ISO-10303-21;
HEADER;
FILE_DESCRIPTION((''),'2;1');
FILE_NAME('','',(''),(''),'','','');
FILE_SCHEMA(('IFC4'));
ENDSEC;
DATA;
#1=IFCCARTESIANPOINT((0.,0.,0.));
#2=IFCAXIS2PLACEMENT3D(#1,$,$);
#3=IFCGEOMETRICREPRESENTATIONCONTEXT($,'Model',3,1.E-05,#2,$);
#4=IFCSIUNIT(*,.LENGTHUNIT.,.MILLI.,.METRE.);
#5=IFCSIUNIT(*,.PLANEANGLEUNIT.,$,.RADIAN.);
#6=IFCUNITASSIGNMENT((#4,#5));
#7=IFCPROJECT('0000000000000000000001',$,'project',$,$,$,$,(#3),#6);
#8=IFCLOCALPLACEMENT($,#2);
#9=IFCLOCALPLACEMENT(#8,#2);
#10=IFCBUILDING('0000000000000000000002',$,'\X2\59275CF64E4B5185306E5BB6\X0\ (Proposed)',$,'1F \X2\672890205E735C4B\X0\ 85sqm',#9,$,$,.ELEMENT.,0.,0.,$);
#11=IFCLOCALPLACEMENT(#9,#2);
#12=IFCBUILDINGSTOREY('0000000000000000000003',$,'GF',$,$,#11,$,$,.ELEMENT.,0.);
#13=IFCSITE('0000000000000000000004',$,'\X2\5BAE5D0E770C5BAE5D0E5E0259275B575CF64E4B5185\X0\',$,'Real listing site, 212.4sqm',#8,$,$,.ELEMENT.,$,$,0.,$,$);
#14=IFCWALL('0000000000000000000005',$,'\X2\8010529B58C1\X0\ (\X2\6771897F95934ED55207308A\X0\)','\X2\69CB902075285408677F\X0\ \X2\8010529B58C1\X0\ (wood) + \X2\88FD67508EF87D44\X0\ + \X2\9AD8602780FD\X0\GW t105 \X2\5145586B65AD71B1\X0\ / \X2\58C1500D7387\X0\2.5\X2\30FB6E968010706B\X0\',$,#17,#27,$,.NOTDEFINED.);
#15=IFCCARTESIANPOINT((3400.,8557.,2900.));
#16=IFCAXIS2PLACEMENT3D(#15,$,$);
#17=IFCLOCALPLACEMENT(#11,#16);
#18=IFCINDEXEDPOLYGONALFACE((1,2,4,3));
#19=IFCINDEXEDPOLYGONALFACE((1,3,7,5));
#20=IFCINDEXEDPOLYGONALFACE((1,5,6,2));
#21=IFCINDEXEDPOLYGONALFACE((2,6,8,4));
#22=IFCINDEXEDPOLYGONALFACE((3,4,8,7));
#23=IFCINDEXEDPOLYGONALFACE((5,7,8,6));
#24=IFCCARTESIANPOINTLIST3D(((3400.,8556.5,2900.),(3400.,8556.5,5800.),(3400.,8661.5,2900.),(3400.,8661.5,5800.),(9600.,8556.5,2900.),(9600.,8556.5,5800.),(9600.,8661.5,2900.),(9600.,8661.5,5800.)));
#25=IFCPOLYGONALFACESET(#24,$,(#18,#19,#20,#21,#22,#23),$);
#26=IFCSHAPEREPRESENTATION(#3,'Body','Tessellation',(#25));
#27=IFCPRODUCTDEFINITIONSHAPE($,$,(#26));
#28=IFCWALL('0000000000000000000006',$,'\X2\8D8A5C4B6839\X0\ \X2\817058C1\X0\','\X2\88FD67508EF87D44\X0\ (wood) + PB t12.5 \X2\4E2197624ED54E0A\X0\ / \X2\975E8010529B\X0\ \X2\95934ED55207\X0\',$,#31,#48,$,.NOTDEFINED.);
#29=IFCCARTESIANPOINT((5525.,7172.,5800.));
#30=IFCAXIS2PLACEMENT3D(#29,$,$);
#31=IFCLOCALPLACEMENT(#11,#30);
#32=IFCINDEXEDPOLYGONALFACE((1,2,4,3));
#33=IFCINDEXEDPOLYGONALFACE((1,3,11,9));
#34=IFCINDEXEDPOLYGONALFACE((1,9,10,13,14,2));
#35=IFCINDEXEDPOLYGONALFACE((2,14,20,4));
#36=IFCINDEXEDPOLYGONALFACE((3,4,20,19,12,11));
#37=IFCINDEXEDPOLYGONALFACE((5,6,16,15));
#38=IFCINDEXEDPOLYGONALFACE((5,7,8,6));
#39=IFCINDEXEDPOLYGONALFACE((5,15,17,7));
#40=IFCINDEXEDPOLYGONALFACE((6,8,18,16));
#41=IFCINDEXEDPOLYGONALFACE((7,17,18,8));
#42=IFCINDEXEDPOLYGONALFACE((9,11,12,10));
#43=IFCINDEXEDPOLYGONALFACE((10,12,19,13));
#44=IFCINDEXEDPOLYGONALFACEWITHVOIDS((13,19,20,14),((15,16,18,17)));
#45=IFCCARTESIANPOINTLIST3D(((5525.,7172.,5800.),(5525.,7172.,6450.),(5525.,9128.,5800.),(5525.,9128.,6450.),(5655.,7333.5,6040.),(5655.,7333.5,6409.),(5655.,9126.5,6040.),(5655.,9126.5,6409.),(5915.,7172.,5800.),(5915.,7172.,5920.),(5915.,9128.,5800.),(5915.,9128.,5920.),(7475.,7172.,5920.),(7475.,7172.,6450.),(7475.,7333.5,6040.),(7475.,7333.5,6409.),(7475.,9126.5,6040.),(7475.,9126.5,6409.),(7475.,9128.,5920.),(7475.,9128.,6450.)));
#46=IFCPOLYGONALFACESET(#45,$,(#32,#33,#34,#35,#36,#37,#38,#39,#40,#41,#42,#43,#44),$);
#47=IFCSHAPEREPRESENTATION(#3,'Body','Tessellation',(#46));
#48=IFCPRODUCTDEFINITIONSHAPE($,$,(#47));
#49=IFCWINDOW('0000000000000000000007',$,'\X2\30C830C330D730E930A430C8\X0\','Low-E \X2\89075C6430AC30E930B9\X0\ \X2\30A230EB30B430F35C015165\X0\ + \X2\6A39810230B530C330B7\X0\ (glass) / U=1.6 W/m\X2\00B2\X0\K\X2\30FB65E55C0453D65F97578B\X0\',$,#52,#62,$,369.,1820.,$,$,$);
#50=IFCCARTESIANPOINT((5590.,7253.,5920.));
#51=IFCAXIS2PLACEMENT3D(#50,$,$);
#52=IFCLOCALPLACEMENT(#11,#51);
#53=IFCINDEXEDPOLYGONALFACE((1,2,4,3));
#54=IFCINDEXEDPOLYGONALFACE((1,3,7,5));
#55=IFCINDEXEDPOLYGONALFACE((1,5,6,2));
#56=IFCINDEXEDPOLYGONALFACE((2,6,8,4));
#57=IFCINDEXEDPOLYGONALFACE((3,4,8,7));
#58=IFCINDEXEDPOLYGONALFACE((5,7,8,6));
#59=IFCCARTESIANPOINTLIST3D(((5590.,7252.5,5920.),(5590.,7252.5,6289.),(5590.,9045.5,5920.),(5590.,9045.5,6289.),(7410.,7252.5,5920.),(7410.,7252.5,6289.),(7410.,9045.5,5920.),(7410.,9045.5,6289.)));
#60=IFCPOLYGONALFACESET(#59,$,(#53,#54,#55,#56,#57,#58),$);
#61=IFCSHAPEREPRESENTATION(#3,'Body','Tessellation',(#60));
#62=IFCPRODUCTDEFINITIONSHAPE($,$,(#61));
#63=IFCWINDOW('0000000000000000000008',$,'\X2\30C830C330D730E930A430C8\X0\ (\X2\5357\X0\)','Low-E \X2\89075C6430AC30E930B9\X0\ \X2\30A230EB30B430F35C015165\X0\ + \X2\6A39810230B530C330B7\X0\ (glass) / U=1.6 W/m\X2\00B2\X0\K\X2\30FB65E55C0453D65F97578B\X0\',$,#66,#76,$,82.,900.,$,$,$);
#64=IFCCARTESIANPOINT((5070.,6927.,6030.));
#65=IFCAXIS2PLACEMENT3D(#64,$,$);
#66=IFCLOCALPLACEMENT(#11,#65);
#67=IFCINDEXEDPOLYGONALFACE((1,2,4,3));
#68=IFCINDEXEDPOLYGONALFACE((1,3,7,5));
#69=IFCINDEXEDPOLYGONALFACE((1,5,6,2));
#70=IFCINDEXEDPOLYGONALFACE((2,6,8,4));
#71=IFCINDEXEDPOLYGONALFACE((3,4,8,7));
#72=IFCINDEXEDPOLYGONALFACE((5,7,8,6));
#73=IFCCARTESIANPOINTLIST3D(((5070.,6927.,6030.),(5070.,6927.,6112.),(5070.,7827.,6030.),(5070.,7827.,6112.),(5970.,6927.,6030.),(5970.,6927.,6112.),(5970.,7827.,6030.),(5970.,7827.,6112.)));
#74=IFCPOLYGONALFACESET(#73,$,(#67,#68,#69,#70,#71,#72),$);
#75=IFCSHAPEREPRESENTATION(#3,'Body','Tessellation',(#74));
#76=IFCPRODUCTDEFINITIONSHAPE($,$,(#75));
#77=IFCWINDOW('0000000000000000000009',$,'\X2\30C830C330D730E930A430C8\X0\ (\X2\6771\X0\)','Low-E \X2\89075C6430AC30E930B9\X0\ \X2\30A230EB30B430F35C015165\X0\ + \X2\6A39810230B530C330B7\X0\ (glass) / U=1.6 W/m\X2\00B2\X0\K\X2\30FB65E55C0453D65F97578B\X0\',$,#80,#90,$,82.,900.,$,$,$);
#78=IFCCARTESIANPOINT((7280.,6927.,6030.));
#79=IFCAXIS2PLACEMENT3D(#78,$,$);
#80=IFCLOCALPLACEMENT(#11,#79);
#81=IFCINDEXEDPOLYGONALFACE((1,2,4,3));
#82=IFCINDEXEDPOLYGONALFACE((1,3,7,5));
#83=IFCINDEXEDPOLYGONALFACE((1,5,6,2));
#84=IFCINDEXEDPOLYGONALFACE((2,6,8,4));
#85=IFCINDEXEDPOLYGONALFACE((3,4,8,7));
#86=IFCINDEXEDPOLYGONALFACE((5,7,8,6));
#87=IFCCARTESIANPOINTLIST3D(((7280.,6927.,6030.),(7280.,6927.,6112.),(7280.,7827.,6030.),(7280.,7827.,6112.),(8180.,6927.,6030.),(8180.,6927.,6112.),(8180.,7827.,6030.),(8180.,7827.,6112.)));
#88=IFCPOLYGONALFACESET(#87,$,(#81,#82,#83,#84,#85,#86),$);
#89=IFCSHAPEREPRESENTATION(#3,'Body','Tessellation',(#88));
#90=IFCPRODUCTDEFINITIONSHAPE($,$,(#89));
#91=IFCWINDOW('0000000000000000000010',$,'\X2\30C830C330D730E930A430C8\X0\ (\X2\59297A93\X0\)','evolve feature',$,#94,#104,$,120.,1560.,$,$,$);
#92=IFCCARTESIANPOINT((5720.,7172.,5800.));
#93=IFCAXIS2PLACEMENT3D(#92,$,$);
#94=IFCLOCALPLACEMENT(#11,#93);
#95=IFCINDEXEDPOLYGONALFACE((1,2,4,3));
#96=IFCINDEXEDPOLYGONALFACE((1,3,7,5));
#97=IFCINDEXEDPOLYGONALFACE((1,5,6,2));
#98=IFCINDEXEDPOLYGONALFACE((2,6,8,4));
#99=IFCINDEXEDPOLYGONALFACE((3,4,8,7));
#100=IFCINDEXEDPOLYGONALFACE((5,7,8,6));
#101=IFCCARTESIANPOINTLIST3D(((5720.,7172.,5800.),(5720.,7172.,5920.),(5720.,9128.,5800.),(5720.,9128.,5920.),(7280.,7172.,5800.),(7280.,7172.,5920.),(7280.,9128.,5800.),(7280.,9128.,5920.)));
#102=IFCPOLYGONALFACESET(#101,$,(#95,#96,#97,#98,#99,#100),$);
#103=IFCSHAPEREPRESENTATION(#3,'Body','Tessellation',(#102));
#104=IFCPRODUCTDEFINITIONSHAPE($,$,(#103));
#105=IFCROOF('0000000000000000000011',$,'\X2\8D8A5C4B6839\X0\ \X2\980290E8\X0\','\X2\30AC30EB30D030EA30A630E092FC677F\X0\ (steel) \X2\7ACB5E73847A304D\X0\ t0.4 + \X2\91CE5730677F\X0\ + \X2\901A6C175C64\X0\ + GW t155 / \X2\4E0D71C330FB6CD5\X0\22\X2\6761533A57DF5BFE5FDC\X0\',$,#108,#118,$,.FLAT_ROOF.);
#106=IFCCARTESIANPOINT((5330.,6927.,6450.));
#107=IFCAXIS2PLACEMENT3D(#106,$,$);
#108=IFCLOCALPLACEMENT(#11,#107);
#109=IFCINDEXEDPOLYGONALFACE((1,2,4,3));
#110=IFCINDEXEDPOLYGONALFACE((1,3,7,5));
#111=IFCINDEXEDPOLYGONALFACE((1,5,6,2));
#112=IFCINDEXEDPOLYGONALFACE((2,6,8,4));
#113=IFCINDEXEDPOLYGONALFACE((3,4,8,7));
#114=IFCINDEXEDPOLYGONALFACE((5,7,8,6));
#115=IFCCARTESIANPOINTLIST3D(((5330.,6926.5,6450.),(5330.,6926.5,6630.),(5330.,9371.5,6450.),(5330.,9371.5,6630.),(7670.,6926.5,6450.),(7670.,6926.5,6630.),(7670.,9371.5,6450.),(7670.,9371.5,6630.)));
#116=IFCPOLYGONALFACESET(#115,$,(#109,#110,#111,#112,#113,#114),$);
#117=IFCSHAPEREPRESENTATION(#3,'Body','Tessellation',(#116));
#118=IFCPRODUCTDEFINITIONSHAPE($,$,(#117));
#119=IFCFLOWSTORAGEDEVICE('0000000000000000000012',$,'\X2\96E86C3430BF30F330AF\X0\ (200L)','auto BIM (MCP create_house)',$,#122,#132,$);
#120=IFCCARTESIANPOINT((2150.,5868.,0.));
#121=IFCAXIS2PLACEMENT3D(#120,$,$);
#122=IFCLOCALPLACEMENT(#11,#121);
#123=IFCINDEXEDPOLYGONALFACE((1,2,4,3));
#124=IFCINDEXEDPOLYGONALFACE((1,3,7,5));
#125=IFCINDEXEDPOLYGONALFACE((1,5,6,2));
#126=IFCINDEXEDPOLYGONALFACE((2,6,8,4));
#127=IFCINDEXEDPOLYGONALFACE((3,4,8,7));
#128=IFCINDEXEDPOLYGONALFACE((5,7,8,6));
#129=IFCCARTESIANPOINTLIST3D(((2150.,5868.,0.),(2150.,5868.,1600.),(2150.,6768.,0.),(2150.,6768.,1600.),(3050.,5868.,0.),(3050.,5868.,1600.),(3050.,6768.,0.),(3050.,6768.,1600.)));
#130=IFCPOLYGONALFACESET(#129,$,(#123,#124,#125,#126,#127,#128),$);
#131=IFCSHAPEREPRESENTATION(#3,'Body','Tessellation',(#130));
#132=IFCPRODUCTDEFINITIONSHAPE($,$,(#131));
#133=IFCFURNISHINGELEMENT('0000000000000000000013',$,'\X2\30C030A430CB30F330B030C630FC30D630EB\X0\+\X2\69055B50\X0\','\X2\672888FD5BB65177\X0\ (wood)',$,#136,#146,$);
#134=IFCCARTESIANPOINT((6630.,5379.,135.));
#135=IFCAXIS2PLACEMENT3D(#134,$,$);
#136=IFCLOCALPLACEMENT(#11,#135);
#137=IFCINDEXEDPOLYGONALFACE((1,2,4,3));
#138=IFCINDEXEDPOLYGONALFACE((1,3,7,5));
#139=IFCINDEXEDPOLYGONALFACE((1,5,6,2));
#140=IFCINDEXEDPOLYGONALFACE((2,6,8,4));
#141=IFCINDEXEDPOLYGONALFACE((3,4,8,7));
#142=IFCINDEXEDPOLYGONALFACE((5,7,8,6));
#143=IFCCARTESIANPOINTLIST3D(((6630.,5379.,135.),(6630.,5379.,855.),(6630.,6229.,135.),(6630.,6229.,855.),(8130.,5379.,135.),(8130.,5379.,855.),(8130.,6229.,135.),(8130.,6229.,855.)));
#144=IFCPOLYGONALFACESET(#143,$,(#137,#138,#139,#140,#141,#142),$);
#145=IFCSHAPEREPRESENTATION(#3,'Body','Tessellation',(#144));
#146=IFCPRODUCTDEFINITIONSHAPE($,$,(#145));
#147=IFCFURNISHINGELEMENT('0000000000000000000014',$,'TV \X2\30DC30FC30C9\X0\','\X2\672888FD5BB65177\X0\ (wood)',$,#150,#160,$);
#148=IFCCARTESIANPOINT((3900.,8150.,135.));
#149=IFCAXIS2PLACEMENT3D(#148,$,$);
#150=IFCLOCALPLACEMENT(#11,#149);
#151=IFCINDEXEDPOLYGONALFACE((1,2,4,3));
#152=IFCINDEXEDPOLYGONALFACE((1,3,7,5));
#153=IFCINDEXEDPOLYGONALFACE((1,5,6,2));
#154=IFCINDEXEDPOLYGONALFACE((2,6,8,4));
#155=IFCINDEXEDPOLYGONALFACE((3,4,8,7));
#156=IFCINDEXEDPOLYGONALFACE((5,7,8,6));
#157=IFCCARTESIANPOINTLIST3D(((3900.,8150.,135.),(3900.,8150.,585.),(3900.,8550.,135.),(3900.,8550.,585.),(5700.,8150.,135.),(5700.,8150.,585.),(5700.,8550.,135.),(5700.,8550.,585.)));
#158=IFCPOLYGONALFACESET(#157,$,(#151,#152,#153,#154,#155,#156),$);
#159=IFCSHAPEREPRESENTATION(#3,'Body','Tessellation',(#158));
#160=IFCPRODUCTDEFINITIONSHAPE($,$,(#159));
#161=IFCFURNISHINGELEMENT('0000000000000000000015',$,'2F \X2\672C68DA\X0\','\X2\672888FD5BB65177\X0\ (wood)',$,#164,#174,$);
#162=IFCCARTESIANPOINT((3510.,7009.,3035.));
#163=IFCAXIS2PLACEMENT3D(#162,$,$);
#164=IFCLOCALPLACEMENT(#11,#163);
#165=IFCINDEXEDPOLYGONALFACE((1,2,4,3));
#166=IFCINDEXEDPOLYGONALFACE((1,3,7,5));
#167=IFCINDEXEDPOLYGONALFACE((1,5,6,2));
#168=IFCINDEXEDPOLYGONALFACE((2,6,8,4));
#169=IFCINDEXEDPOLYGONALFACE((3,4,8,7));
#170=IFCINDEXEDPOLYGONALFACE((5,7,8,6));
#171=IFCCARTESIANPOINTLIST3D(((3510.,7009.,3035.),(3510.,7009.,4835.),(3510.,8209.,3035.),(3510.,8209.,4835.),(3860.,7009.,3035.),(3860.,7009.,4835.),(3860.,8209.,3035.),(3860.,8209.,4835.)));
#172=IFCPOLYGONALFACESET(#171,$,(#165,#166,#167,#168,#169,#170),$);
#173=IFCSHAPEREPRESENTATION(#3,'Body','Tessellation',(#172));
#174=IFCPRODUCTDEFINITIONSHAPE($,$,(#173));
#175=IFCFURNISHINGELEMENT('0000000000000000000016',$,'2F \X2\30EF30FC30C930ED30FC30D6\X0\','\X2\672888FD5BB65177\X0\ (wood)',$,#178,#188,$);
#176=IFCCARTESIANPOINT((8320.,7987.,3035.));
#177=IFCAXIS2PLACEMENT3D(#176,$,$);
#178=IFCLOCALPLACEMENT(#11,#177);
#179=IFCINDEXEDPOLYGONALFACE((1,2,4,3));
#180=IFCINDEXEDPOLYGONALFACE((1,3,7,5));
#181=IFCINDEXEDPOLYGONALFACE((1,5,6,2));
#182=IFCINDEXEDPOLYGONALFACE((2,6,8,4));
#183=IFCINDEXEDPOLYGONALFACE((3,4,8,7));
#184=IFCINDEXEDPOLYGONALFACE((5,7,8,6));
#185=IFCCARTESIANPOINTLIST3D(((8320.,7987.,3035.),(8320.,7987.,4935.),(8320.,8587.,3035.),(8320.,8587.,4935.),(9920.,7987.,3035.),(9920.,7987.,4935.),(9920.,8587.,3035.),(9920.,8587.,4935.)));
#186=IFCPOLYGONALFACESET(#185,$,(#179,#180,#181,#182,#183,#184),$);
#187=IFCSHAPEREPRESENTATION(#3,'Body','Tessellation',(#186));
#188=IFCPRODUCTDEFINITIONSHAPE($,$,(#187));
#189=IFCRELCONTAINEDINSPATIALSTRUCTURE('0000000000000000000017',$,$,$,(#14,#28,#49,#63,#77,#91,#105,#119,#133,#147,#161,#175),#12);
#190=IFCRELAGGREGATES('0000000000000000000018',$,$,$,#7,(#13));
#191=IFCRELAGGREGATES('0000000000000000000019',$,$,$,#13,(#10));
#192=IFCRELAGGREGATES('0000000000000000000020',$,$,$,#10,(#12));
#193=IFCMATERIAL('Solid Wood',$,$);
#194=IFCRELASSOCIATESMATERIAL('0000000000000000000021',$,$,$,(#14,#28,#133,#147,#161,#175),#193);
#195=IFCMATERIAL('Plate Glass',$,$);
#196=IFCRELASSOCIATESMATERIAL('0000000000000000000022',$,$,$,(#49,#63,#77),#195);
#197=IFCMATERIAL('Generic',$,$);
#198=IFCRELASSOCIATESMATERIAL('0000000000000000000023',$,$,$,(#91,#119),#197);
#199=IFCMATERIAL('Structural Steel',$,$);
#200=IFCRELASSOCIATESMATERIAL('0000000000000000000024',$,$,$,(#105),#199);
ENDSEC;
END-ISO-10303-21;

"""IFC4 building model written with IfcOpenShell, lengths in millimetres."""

from ifc_helpers import new_model, si_unit, frame, frame_2d, origin, place, context, project, spatial, rectangle, extrude, material, element, fill, save


model = new_model("IFC4")

# Units and contexts
model_context = context("Model", 3, precision=1e-05, world=origin())
ifc_project = project(units=[si_unit("LENGTHUNIT", "METRE", prefix="MILLI"), si_unit("PLANEANGLEUNIT", "RADIAN")], contexts=[model_context])

# Site, building, storey
site_placement = place(None, origin())
site = spatial("IfcSite", under=ifc_project, at=site_placement, Name="宮崎県宮崎市大字島之内", ObjectType="Real listing site, 212.4sqm", CompositionType="ELEMENT", RefElevation=0.0)
building_placement = place(site_placement, origin())
building = spatial("IfcBuilding", under=site, at=building_placement, Name="大島之内の家 (Proposed)", ObjectType="1F 木造平屋 85sqm", CompositionType="ELEMENT", ElevationOfRefHeight=0.0, ElevationOfTerrain=0.0)
storey_placement = place(building_placement, origin())
storey = spatial("IfcBuildingStorey", under=building, at=storey_placement, Name="GF", CompositionType="ELEMENT", Elevation=0.0)

# Wall
ifc_material_1 = material(Name="Solid Wood")
wall_1_placement = place(storey_placement, frame((3400.0, 8557.0, 2900.0)))
element("IfcWall", 1, at=wall_1_placement, inside=storey, material=ifc_material_1, Name="耐力壁 (東西間仕切り)", Description="構造用合板 耐力壁 (wood) + 製材軸組 + 高性能GW t105 充填断熱 / 壁倍率2.5・準耐火", PredefinedType="NOTDEFINED", context=model_context, shape_type="SweptSolid", body=[
    extrude(rectangle(XDim=6200.0, YDim=105.0, at=frame_2d((3100.0, 52.0))), frame((3400.0, 8557.0, 2900.0)), (0.0, 0.0, 1.0), 2900.0),
])

# Wall, openings, windows
wall_2_placement = place(storey_placement, frame((5525.0, 7172.0, 5800.0)))
wall_2 = element("IfcWall", 2, at=wall_2_placement, inside=storey, material=ifc_material_1, Name="越屋根 腰壁", Description="製材軸組 (wood) + PB t12.5 両面仕上 / 非耐力 間仕切", PredefinedType="NOTDEFINED", context=model_context, shape_type="SweptSolid", body=[
    extrude(rectangle(XDim=1950.0, YDim=1956.0, at=frame_2d((975.0, 978.0))), frame((5525.0, 7172.0, 5800.0)), (0.0, 0.0, 1.0), 650.0),
])
opening_1_placement = place(storey_placement, frame((5590.0, 7253.0, 5920.0)))
opening_1 = element("IfcOpeningElement", 3, at=opening_1_placement, cuts=wall_2, PredefinedType="NOTDEFINED", context=model_context, shape_type="SweptSolid", body=[
    extrude(rectangle(XDim=1820.0, YDim=1793.0, at=frame_2d((910.0, 896.0))), frame((5590.0, 7253.0, 5920.0)), (0.0, 0.0, 1.0), 369.0),
])
opening_2_placement = place(storey_placement, frame((5070.0, 6927.0, 6030.0)))
opening_2 = element("IfcOpeningElement", 4, at=opening_2_placement, cuts=wall_2, PredefinedType="NOTDEFINED", context=model_context, shape_type="SweptSolid", body=[
    extrude(rectangle(XDim=900.0, YDim=900.0, at=frame_2d((450.0, 450.0))), frame((5070.0, 6927.0, 6030.0)), (0.0, 0.0, 1.0), 82.0),
])
opening_3_placement = place(storey_placement, frame((7280.0, 6927.0, 6030.0)))
opening_3 = element("IfcOpeningElement", 5, at=opening_3_placement, cuts=wall_2, PredefinedType="NOTDEFINED", context=model_context, shape_type="SweptSolid", body=[
    extrude(rectangle(XDim=900.0, YDim=900.0, at=frame_2d((450.0, 450.0))), frame((7280.0, 6927.0, 6030.0)), (0.0, 0.0, 1.0), 82.0),
])
opening_4_placement = place(storey_placement, frame((5720.0, 7172.0, 5800.0)))
opening_4 = element("IfcOpeningElement", 6, at=opening_4_placement, cuts=wall_2, PredefinedType="NOTDEFINED", context=model_context, shape_type="SweptSolid", body=[
    extrude(rectangle(XDim=1560.0, YDim=1956.0, at=frame_2d((780.0, 978.0))), frame((5720.0, 7172.0, 5800.0)), (0.0, 0.0, 1.0), 120.0),
])
ifc_material_2 = material(Name="Plate Glass")
window_1_placement = place(storey_placement, frame((5590.0, 7253.0, 5920.0)))
window_1 = element("IfcWindow", 7, at=window_1_placement, inside=storey, material=ifc_material_2, Name="トップライト", Description="Low-E 複層ガラス アルゴン封入 + 樹脂サッシ (glass) / U=1.6 W/m²K・日射取得型", OverallHeight=369.0, OverallWidth=1820.0, context=model_context, shape_type="SweptSolid", body=[
    extrude(rectangle(XDim=1820.0, YDim=1793.0, at=frame_2d((910.0, 896.0))), frame((5590.0, 7253.0, 5920.0)), (0.0, 0.0, 1.0), 369.0),
])
fill(opening_1, window_1)
window_2_placement = place(storey_placement, frame((5070.0, 6927.0, 6030.0)))
window_2 = element("IfcWindow", 8, at=window_2_placement, inside=storey, material=ifc_material_2, Name="トップライト (南)", Description="Low-E 複層ガラス アルゴン封入 + 樹脂サッシ (glass) / U=1.6 W/m²K・日射取得型", OverallHeight=82.0, OverallWidth=900.0, context=model_context, shape_type="SweptSolid", body=[
    extrude(rectangle(XDim=900.0, YDim=900.0, at=frame_2d((450.0, 450.0))), frame((5070.0, 6927.0, 6030.0)), (0.0, 0.0, 1.0), 82.0),
])
fill(opening_2, window_2)
window_3_placement = place(storey_placement, frame((7280.0, 6927.0, 6030.0)))
window_3 = element("IfcWindow", 9, at=window_3_placement, inside=storey, material=ifc_material_2, Name="トップライト (東)", Description="Low-E 複層ガラス アルゴン封入 + 樹脂サッシ (glass) / U=1.6 W/m²K・日射取得型", OverallHeight=82.0, OverallWidth=900.0, context=model_context, shape_type="SweptSolid", body=[
    extrude(rectangle(XDim=900.0, YDim=900.0, at=frame_2d((450.0, 450.0))), frame((7280.0, 6927.0, 6030.0)), (0.0, 0.0, 1.0), 82.0),
])
fill(opening_3, window_3)
ifc_material_3 = material(Name="Generic")
window_4_placement = place(storey_placement, frame((5720.0, 7172.0, 5800.0)))
window_4 = element("IfcWindow", 10, at=window_4_placement, inside=storey, material=ifc_material_3, Name="トップライト (天窓)", Description="evolve feature", OverallHeight=120.0, OverallWidth=1560.0, context=model_context, shape_type="SweptSolid", body=[
    extrude(rectangle(XDim=1560.0, YDim=1956.0, at=frame_2d((780.0, 978.0))), frame((5720.0, 7172.0, 5800.0)), (0.0, 0.0, 1.0), 120.0),
])
fill(opening_4, window_4)

# Roof
ifc_material_4 = material(Name="Structural Steel")
roof_placement = place(storey_placement, frame((5330.0, 6927.0, 6450.0)))
element("IfcRoof", 11, at=roof_placement, inside=storey, material=ifc_material_4, Name="越屋根 頂部", Description="ガルバリウム鋼板 (steel) 立平葺き t0.4 + 野地板 + 通気層 + GW t155 / 不燃・法22条区域対応", PredefinedType="FLAT_ROOF", context=model_context, shape_type="SweptSolid", body=[
    extrude(rectangle(XDim=2340.0, YDim=2445.0, at=frame_2d((1170.0, 1222.0))), frame((5330.0, 6927.0, 6450.0)), (0.0, 0.0, 1.0), 180.0),
])

# Flow storage device
flow_storage_device_placement = place(storey_placement, frame((2150.0, 5868.0, 0.0)))
element("IfcFlowStorageDevice", 12, at=flow_storage_device_placement, inside=storey, material=ifc_material_3, Name="雨水タンク (200L)", Description="auto BIM (MCP create_house)", context=model_context, shape_type="SweptSolid", body=[
    extrude(rectangle(XDim=900.0, YDim=900.0, at=frame_2d((450.0, 450.0))), frame((2150.0, 5868.0, 0.0)), (0.0, 0.0, 1.0), 1600.0),
])

# Furnishing elements
furnishing_1_placement = place(storey_placement, frame((6630.0, 5379.0, 135.0)))
element("IfcFurnishingElement", 13, at=furnishing_1_placement, inside=storey, material=ifc_material_1, Name="ダイニングテーブル+椅子", Description="木製家具 (wood)", context=model_context, shape_type="SweptSolid", body=[
    extrude(rectangle(XDim=1500.0, YDim=850.0, at=frame_2d((750.0, 425.0))), frame((6630.0, 5379.0, 135.0)), (0.0, 0.0, 1.0), 720.0),
])
furnishing_2_placement = place(storey_placement, frame((3900.0, 8150.0, 135.0)))
element("IfcFurnishingElement", 14, at=furnishing_2_placement, inside=storey, material=ifc_material_1, Name="TV ボード", Description="木製家具 (wood)", context=model_context, shape_type="SweptSolid", body=[
    extrude(rectangle(XDim=1800.0, YDim=400.0, at=frame_2d((900.0, 200.0))), frame((3900.0, 8150.0, 135.0)), (0.0, 0.0, 1.0), 450.0),
])
furnishing_3_placement = place(storey_placement, frame((3510.0, 7009.0, 3035.0)))
element("IfcFurnishingElement", 15, at=furnishing_3_placement, inside=storey, material=ifc_material_1, Name="2F 本棚", Description="木製家具 (wood)", context=model_context, shape_type="SweptSolid", body=[
    extrude(rectangle(XDim=350.0, YDim=1200.0, at=frame_2d((175.0, 600.0))), frame((3510.0, 7009.0, 3035.0)), (0.0, 0.0, 1.0), 1800.0),
])
furnishing_4_placement = place(storey_placement, frame((8320.0, 7987.0, 3035.0)))
element("IfcFurnishingElement", 16, at=furnishing_4_placement, inside=storey, material=ifc_material_1, Name="2F ワードローブ", Description="木製家具 (wood)", context=model_context, shape_type="SweptSolid", body=[
    extrude(rectangle(XDim=1600.0, YDim=600.0, at=frame_2d((800.0, 300.0))), frame((8320.0, 7987.0, 3035.0)), (0.0, 0.0, 1.0), 1900.0),
])

save(model, "model.ifc")
